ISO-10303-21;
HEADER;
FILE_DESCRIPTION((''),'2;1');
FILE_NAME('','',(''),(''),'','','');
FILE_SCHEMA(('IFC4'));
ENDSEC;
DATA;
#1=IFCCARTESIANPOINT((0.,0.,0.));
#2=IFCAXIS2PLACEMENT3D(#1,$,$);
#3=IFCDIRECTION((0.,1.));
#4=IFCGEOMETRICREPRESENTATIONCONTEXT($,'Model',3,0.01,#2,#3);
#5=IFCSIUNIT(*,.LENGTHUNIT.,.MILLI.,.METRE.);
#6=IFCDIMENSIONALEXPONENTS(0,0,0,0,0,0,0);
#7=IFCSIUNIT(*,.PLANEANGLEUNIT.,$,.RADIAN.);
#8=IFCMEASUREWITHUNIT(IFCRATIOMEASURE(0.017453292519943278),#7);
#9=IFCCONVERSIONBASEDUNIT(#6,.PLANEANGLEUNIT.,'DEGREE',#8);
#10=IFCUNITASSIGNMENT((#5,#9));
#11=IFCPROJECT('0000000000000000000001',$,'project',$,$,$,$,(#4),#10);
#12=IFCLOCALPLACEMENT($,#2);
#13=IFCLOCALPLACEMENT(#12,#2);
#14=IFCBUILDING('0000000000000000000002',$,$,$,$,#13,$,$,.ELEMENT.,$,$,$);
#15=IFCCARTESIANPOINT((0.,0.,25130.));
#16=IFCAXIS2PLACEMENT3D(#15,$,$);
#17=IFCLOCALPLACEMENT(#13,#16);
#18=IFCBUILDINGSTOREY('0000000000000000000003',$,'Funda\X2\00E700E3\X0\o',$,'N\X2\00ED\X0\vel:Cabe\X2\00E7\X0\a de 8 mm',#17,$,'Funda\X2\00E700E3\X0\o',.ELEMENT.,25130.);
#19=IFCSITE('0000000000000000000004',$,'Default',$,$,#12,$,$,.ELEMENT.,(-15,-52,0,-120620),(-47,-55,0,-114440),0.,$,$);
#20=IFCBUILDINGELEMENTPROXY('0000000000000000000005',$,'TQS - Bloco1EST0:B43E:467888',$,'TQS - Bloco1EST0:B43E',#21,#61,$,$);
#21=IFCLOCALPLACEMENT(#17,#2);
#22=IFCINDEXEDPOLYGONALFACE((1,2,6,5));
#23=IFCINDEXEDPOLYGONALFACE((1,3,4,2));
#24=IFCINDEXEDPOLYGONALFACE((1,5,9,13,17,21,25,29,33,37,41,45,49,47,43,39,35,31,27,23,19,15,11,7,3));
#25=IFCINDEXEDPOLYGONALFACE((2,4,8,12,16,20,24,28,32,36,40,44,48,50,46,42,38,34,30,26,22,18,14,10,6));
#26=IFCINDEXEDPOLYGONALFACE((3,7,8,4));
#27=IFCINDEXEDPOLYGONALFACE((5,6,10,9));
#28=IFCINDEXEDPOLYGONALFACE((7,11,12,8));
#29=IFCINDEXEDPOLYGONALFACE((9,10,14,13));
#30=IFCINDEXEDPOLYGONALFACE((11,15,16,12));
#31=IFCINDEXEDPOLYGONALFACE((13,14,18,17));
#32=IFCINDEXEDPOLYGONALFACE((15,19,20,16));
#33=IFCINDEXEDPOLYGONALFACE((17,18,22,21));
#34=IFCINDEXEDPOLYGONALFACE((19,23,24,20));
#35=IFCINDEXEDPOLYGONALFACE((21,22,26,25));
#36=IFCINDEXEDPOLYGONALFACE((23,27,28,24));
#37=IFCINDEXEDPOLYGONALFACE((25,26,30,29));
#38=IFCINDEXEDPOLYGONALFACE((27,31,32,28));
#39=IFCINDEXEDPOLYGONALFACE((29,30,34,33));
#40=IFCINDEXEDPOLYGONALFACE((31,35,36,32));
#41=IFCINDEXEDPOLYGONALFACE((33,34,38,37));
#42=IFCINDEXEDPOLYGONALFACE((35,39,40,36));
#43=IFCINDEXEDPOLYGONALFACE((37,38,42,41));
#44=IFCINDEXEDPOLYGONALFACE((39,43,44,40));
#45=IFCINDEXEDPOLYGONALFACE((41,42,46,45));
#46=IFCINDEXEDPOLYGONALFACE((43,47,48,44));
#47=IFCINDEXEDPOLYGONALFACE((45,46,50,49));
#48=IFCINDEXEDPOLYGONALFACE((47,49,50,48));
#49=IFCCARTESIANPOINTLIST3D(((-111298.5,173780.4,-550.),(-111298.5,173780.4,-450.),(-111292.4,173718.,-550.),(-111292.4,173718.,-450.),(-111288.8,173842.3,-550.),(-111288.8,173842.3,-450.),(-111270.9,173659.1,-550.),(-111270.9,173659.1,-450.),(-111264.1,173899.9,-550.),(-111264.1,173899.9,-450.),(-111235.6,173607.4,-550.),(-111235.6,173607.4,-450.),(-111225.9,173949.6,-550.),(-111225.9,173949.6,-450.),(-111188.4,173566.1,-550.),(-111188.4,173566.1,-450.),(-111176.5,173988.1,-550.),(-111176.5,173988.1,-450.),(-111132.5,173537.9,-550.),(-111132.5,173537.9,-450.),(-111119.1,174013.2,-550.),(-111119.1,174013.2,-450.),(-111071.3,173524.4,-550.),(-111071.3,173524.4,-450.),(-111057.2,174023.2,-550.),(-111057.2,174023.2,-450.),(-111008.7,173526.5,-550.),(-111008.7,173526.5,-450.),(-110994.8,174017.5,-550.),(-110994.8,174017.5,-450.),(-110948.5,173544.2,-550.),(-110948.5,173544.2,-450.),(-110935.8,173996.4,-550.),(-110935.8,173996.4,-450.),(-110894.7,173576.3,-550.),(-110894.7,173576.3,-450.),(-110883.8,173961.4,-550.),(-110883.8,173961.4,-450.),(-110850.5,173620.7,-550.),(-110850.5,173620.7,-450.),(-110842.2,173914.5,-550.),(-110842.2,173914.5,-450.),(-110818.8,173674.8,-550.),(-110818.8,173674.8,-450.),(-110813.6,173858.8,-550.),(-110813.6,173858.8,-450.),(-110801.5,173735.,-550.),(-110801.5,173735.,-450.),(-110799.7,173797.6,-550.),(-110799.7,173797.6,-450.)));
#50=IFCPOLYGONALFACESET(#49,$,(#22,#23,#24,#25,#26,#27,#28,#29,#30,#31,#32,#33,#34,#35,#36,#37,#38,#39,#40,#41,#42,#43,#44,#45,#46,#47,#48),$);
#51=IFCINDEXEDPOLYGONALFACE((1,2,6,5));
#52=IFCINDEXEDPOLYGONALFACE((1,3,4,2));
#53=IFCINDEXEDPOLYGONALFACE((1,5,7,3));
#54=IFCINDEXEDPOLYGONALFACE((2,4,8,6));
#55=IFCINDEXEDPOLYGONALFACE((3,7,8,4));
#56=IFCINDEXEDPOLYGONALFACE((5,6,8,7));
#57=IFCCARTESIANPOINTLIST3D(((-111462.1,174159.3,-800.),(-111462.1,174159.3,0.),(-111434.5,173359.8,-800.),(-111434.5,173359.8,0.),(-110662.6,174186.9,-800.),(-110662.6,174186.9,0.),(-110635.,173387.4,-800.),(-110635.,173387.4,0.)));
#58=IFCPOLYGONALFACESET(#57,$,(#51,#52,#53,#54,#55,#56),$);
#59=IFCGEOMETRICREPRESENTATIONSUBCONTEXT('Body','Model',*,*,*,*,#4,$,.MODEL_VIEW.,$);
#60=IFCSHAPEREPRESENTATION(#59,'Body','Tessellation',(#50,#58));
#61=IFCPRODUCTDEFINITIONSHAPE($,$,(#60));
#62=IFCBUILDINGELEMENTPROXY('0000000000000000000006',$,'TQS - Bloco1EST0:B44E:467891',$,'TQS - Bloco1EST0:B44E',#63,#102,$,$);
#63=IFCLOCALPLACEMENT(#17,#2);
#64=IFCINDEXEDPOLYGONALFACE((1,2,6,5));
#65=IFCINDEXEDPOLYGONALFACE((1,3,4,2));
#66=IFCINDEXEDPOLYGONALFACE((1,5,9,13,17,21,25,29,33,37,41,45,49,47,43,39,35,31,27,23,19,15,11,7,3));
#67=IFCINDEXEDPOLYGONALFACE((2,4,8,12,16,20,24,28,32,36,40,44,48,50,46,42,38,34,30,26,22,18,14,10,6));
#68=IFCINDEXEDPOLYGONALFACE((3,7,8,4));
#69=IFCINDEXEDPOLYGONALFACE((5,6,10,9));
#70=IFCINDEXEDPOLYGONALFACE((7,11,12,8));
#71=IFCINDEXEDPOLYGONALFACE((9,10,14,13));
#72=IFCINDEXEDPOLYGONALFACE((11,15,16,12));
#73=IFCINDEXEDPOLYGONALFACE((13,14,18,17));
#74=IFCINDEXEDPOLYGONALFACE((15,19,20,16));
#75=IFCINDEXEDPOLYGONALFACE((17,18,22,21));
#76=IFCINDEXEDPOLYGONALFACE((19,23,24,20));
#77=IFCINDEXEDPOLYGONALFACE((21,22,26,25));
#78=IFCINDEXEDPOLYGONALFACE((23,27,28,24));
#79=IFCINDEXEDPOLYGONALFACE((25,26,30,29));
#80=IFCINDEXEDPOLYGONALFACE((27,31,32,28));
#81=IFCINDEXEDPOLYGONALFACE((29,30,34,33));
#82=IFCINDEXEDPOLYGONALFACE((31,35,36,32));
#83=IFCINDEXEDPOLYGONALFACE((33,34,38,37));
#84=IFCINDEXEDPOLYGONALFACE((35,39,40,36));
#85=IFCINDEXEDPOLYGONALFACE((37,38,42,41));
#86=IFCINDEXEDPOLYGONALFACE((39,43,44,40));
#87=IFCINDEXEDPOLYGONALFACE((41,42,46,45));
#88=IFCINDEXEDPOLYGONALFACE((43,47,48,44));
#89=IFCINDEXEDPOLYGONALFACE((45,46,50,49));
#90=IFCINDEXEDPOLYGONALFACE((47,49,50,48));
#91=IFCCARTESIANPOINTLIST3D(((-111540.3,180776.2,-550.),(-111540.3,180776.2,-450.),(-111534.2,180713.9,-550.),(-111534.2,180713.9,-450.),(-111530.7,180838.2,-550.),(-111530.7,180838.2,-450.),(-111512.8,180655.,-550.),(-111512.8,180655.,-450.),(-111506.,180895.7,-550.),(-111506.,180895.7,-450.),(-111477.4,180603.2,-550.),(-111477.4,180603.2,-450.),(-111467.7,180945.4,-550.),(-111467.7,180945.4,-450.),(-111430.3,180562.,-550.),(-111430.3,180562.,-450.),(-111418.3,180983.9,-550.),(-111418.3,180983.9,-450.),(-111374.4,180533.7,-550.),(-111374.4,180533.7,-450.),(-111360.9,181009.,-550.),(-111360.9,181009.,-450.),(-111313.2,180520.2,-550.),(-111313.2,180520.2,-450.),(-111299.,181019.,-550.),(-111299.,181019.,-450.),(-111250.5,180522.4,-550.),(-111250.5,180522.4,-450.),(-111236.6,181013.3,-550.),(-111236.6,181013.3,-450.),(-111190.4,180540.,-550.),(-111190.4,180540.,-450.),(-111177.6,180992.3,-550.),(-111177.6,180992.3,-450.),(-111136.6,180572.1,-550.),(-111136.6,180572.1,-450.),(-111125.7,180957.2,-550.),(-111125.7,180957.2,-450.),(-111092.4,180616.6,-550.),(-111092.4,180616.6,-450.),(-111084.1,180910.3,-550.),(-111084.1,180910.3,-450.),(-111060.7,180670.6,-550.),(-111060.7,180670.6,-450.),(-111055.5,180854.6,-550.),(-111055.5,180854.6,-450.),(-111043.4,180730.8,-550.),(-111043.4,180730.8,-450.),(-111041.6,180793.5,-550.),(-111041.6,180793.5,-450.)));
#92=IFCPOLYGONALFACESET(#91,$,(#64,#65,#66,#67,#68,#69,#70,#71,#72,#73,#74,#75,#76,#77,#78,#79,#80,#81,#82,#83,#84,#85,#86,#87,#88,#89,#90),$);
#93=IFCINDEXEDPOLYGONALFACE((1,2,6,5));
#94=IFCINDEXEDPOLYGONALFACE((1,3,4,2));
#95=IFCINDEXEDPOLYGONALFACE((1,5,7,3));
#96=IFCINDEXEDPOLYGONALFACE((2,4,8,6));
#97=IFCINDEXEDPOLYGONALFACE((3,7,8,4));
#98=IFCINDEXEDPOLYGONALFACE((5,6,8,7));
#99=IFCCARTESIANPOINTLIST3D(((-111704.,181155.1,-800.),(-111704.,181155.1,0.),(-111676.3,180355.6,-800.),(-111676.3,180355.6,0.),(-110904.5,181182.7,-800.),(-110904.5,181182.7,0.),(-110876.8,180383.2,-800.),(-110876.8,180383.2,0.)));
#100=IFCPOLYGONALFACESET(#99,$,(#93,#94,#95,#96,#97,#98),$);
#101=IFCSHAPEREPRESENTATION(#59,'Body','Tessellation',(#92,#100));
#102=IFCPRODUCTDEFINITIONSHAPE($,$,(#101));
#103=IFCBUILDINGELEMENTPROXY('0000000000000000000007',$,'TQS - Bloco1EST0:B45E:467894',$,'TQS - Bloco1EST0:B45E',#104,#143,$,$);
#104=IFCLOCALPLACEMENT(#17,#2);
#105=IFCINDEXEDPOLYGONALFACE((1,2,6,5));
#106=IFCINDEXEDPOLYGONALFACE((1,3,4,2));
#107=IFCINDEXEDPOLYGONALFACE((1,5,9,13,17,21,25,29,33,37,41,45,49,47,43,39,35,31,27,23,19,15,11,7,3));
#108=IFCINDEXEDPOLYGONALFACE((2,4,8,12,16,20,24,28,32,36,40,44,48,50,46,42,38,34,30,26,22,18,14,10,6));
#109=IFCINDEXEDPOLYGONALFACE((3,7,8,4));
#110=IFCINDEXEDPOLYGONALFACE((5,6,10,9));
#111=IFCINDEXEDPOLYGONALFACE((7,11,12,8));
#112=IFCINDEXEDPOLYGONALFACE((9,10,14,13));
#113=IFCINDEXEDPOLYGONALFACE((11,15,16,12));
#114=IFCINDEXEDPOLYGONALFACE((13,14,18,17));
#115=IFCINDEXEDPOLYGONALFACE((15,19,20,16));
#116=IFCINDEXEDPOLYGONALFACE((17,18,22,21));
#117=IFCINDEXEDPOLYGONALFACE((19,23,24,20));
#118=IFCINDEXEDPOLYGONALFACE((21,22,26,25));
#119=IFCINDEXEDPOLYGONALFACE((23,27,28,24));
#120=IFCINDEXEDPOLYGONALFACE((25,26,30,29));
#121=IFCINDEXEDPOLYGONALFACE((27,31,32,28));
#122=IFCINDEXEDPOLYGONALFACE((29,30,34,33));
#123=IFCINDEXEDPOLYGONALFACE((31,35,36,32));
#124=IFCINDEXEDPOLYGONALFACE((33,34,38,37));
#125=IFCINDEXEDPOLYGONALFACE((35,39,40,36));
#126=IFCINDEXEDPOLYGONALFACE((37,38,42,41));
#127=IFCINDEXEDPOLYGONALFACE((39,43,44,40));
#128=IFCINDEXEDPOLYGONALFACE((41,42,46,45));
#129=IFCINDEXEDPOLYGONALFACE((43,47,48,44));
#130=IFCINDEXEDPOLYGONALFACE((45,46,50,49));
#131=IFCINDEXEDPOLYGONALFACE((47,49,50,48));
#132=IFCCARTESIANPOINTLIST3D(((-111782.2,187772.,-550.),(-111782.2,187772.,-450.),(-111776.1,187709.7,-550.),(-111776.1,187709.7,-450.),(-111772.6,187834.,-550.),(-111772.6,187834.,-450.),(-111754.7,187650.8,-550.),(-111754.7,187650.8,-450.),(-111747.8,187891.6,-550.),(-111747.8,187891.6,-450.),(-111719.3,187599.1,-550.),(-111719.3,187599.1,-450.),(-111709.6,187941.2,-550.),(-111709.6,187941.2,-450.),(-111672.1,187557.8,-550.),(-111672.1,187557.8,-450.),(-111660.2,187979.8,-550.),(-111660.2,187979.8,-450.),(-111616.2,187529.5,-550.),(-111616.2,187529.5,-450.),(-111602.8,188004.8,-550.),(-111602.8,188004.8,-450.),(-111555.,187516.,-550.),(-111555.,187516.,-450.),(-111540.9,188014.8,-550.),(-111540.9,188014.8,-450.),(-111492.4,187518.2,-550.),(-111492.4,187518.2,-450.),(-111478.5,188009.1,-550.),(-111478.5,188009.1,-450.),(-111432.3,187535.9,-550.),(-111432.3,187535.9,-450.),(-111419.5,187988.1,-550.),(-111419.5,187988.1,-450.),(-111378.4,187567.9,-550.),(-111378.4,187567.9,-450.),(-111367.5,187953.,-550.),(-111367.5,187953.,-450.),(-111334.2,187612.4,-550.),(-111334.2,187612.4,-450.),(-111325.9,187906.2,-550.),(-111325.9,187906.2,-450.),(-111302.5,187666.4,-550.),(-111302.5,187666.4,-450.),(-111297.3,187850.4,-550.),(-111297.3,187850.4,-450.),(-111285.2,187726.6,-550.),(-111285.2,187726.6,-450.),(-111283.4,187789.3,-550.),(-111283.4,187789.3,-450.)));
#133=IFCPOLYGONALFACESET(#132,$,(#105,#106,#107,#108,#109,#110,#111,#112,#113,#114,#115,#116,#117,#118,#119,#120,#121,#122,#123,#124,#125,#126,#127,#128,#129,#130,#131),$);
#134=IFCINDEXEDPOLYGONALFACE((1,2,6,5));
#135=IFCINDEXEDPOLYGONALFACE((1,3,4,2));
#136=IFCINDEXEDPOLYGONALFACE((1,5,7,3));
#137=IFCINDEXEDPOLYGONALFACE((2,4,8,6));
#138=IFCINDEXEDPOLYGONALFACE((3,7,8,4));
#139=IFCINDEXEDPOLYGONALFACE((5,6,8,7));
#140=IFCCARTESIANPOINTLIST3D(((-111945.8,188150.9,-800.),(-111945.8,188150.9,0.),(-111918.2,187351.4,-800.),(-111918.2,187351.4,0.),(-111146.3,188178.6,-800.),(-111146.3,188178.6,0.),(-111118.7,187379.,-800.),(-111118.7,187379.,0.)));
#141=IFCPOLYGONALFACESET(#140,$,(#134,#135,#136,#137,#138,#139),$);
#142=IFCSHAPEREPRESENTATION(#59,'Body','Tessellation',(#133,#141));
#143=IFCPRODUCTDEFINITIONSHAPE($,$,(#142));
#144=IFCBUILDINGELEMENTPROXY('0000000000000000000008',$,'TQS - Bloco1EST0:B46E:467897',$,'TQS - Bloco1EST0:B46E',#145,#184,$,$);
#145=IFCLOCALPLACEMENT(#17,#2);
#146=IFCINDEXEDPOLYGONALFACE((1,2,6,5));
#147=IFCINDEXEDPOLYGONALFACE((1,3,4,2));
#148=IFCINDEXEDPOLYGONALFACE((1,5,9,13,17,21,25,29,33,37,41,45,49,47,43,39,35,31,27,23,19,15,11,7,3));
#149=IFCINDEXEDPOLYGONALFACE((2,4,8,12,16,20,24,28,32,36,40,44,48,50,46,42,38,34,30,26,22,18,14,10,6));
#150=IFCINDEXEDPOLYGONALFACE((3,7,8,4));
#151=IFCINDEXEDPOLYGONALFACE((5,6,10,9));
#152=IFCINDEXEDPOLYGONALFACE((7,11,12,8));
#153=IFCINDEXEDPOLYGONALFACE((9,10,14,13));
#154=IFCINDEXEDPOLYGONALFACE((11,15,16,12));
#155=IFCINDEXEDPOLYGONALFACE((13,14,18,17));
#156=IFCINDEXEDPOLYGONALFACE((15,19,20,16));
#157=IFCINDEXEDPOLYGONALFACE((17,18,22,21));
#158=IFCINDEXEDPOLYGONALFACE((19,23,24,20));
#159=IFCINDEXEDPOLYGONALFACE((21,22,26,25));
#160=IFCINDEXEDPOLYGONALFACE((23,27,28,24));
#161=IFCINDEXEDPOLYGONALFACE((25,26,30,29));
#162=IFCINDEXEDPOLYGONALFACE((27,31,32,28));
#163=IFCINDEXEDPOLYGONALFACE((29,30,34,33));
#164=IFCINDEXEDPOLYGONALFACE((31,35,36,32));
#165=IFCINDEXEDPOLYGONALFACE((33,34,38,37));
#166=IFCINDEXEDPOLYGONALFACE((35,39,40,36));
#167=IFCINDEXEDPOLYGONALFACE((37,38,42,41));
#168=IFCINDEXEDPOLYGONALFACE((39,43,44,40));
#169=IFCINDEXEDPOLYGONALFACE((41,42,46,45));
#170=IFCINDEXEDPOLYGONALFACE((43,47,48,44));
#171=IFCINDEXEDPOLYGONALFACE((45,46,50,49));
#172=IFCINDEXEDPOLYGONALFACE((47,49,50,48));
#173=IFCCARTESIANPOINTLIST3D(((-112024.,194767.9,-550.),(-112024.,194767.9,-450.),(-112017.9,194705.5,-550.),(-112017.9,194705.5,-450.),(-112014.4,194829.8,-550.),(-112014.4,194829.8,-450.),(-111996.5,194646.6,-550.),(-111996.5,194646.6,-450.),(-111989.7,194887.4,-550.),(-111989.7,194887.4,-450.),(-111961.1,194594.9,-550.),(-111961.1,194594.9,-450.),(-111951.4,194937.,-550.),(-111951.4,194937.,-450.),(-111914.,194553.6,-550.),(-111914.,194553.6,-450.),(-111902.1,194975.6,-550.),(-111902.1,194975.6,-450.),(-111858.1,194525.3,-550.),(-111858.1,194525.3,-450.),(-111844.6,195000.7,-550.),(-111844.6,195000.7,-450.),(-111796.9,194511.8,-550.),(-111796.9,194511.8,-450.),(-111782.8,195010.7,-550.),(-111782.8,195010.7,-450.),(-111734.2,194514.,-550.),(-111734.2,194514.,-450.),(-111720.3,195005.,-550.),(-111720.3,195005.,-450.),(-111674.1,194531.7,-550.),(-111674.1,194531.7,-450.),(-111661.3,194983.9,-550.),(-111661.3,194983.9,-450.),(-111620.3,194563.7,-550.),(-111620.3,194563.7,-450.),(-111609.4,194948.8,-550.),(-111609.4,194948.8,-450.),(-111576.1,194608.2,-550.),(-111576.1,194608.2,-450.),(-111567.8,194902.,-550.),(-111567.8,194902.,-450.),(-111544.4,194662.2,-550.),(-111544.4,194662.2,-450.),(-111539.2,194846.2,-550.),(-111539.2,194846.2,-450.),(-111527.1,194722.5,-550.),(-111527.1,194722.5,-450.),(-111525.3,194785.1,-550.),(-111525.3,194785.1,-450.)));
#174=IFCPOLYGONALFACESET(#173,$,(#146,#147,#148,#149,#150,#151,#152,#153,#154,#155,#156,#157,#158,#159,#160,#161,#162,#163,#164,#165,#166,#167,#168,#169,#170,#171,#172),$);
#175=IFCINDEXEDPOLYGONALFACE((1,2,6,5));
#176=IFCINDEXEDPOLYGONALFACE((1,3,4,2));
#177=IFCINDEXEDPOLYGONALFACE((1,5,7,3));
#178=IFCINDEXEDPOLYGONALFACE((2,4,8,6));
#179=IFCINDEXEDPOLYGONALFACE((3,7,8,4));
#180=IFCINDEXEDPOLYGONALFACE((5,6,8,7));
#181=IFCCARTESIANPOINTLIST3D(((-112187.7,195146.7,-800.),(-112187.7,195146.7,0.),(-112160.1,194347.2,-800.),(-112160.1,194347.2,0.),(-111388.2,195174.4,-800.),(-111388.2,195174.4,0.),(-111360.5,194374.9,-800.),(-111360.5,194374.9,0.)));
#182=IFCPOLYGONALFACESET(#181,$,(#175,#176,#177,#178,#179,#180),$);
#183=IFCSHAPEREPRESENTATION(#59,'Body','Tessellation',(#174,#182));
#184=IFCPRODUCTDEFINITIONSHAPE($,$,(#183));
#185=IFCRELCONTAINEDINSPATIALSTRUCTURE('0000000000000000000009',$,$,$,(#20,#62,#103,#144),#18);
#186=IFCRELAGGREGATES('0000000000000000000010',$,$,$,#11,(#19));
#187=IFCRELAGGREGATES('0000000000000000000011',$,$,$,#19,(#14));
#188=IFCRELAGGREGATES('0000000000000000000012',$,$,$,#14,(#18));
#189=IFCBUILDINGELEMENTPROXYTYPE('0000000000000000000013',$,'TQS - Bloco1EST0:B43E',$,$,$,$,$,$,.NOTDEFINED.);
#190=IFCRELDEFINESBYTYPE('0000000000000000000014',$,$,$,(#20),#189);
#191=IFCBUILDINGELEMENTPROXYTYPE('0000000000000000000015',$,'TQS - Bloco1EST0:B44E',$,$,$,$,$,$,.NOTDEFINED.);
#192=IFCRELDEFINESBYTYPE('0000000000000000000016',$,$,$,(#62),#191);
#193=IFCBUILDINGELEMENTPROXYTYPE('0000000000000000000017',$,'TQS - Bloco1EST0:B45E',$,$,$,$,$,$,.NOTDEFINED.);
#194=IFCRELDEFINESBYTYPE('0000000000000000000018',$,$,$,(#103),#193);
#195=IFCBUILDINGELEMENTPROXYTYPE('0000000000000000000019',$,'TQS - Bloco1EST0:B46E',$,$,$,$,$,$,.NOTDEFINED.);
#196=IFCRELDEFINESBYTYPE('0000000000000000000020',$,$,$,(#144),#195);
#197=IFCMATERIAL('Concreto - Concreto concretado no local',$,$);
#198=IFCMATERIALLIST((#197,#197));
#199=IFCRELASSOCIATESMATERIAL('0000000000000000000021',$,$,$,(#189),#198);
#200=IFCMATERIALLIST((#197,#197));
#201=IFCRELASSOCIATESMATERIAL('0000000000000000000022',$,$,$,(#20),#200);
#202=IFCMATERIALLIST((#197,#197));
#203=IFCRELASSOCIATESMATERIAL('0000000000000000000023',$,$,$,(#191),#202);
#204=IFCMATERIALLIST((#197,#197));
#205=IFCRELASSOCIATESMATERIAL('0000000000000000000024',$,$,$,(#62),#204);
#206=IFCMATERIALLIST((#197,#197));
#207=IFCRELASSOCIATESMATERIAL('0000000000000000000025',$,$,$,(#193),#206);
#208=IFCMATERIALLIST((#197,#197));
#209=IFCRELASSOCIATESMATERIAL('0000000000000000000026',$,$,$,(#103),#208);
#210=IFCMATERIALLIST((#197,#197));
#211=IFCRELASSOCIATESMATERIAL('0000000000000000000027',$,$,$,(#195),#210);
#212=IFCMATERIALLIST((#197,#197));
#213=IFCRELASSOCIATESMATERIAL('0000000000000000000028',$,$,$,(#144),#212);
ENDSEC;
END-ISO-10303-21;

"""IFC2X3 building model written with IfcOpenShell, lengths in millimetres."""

from ifc_helpers import new_model, entity, si_unit, converted_unit, direction, frame, frame_2d, origin, origin_2d_with_axis, place, context, subcontext, project, spatial, rectangle, circle, extrude, source, transform, mapped, material, material_list, type_object, type_shapes, element, save


model = new_model("IFC2X3")

# Units and contexts
model_context = context("Model", 3, precision=0.01, world=origin(), true_north=direction((0.0, 1.0)))
body_context = subcontext(model_context, "Body", "Model", "MODEL_VIEW")
ifc_project = project(units=[si_unit("LENGTHUNIT", "METRE", prefix="MILLI"), converted_unit("PLANEANGLEUNIT", "DEGREE", entity("IfcRatioMeasure", 0.017453292519943278), si_unit("PLANEANGLEUNIT", "RADIAN"), dimensions=[0, 0, 0, 0, 0, 0, 0])], contexts=[model_context])

# Site, building, storey
site_placement = place(None, origin())
site = spatial("IfcSite", under=ifc_project, at=site_placement, Name="Default", CompositionType="ELEMENT", RefLatitude=(-15, -52, 0, -120620), RefLongitude=(-47, -55, 0, -114440), RefElevation=0.0)
building_placement = place(site_placement, origin())
building = spatial("IfcBuilding", under=site, at=building_placement, CompositionType="ELEMENT")
storey_placement = place(building_placement, frame((0.0, 0.0, 25130.0)))
storey = spatial("IfcBuildingStorey", under=building, at=storey_placement, Name="Fundação", ObjectType="Nível:Cabeça de 8 mm", LongName="Fundação", CompositionType="ELEMENT", Elevation=25130.0)

# Building element proxies
ifc_material_1 = material(Name="Concreto - Concreto concretado no local")
ifc_material_list_1 = material_list([ifc_material_1, ifc_material_1])
ifc_material_list_2 = material_list([ifc_material_1, ifc_material_1])
building_element_proxy_type_1 = type_object("IfcBuildingElementProxyType", Name="TQS - Bloco1EST0:B43E", PredefinedType="NOTDEFINED", material=ifc_material_list_2)
shared_shape_1 = source(origin(), body_context, "Body", "SweptSolid", [
    extrude(circle(Radius=250.0, at=frame_2d((0.0, 0.0), x_axis=(1.0, 0.0))), frame((0.0, 0.0, -550.0)), (0.0, 0.0, 1.0), 100.0),
    extrude(rectangle(XDim=800.0, YDim=800.0, at=origin_2d_with_axis()), frame((0.0, 0.0, -800.0), z_axis=(0.0, 0.0, 1.0), x_axis=(-1.0, 0.0, 0.0)), (0.0, 0.0, 1.0), 800.0),
])
type_shapes(building_element_proxy_type_1, [shared_shape_1])
proxy_1_placement = place(storey_placement, frame((-111048.6, 173773.3, 0.0), z_axis=(0.0, 0.0, 1.0), x_axis=(-0.034551, 0.999403, 0.0)))
element("IfcBuildingElementProxy", 1, at=proxy_1_placement, inside=storey, type_object=building_element_proxy_type_1, material=ifc_material_list_1, Name="TQS - Bloco1EST0:B43E:467888", ObjectType="TQS - Bloco1EST0:B43E", context=body_context, shape_type="MappedRepresentation", body=[
    mapped(shared_shape_1, transform((0.0, 0.0, 0.0), scale=1.0)),
])
ifc_material_list_3 = material_list([ifc_material_1, ifc_material_1])
ifc_material_list_4 = material_list([ifc_material_1, ifc_material_1])
building_element_proxy_type_2 = type_object("IfcBuildingElementProxyType", Name="TQS - Bloco1EST0:B44E", PredefinedType="NOTDEFINED", material=ifc_material_list_4)
shared_shape_2 = source(origin(), body_context, "Body", "SweptSolid", [
    extrude(circle(Radius=250.0, at=frame_2d((0.0, 0.0), x_axis=(1.0, 0.0))), frame((0.0, 0.0, -550.0)), (0.0, 0.0, 1.0), 100.0),
    extrude(rectangle(XDim=800.0, YDim=800.0, at=origin_2d_with_axis()), frame((0.0, 0.0, -800.0), z_axis=(0.0, 0.0, 1.0), x_axis=(-1.0, 0.0, 0.0)), (0.0, 0.0, 1.0), 800.0),
])
type_shapes(building_element_proxy_type_2, [shared_shape_2])
proxy_2_placement = place(storey_placement, frame((-111290.4, 180769.2, 0.0), z_axis=(0.0, 0.0, 1.0), x_axis=(-0.034551, 0.999403, 0.0)))
element("IfcBuildingElementProxy", 2, at=proxy_2_placement, inside=storey, type_object=building_element_proxy_type_2, material=ifc_material_list_3, Name="TQS - Bloco1EST0:B44E:467891", ObjectType="TQS - Bloco1EST0:B44E", context=body_context, shape_type="MappedRepresentation", body=[
    mapped(shared_shape_2, transform((0.0, 0.0, 0.0), scale=1.0)),
])
ifc_material_list_5 = material_list([ifc_material_1, ifc_material_1])
ifc_material_list_6 = material_list([ifc_material_1, ifc_material_1])
building_element_proxy_type_3 = type_object("IfcBuildingElementProxyType", Name="TQS - Bloco1EST0:B45E", PredefinedType="NOTDEFINED", material=ifc_material_list_6)
shared_shape_3 = source(origin(), body_context, "Body", "SweptSolid", [
    extrude(circle(Radius=250.0, at=frame_2d((0.0, 0.0), x_axis=(1.0, 0.0))), frame((0.0, 0.0, -550.0)), (0.0, 0.0, 1.0), 100.0),
    extrude(rectangle(XDim=800.0, YDim=800.0, at=origin_2d_with_axis()), frame((0.0, 0.0, -800.0), z_axis=(0.0, 0.0, 1.0), x_axis=(-1.0, 0.0, 0.0)), (0.0, 0.0, 1.0), 800.0),
])
type_shapes(building_element_proxy_type_3, [shared_shape_3])
proxy_3_placement = place(storey_placement, frame((-111532.3, 187765.0, 0.0), z_axis=(0.0, 0.0, 1.0), x_axis=(-0.034551, 0.999403, 0.0)))
element("IfcBuildingElementProxy", 3, at=proxy_3_placement, inside=storey, type_object=building_element_proxy_type_3, material=ifc_material_list_5, Name="TQS - Bloco1EST0:B45E:467894", ObjectType="TQS - Bloco1EST0:B45E", context=body_context, shape_type="MappedRepresentation", body=[
    mapped(shared_shape_3, transform((0.0, 0.0, 0.0), scale=1.0)),
])
ifc_material_list_7 = material_list([ifc_material_1, ifc_material_1])
ifc_material_list_8 = material_list([ifc_material_1, ifc_material_1])
building_element_proxy_type_4 = type_object("IfcBuildingElementProxyType", Name="TQS - Bloco1EST0:B46E", PredefinedType="NOTDEFINED", material=ifc_material_list_8)
shared_shape_4 = source(origin(), body_context, "Body", "SweptSolid", [
    extrude(circle(Radius=250.0, at=frame_2d((0.0, 0.0), x_axis=(1.0, 0.0))), frame((0.0, 0.0, -550.0)), (0.0, 0.0, 1.0), 100.0),
    extrude(rectangle(XDim=800.0, YDim=800.0, at=origin_2d_with_axis()), frame((0.0, 0.0, -800.0), z_axis=(0.0, 0.0, 1.0), x_axis=(-1.0, 0.0, 0.0)), (0.0, 0.0, 1.0), 800.0),
])
type_shapes(building_element_proxy_type_4, [shared_shape_4])
proxy_4_placement = place(storey_placement, frame((-111774.1, 194760.8, 0.0), z_axis=(0.0, 0.0, 1.0), x_axis=(-0.034551, 0.999403, 0.0)))
element("IfcBuildingElementProxy", 4, at=proxy_4_placement, inside=storey, type_object=building_element_proxy_type_4, material=ifc_material_list_7, Name="TQS - Bloco1EST0:B46E:467897", ObjectType="TQS - Bloco1EST0:B46E", context=body_context, shape_type="MappedRepresentation", body=[
    mapped(shared_shape_4, transform((0.0, 0.0, 0.0), scale=1.0)),
])

save(model, "model.ifc")
